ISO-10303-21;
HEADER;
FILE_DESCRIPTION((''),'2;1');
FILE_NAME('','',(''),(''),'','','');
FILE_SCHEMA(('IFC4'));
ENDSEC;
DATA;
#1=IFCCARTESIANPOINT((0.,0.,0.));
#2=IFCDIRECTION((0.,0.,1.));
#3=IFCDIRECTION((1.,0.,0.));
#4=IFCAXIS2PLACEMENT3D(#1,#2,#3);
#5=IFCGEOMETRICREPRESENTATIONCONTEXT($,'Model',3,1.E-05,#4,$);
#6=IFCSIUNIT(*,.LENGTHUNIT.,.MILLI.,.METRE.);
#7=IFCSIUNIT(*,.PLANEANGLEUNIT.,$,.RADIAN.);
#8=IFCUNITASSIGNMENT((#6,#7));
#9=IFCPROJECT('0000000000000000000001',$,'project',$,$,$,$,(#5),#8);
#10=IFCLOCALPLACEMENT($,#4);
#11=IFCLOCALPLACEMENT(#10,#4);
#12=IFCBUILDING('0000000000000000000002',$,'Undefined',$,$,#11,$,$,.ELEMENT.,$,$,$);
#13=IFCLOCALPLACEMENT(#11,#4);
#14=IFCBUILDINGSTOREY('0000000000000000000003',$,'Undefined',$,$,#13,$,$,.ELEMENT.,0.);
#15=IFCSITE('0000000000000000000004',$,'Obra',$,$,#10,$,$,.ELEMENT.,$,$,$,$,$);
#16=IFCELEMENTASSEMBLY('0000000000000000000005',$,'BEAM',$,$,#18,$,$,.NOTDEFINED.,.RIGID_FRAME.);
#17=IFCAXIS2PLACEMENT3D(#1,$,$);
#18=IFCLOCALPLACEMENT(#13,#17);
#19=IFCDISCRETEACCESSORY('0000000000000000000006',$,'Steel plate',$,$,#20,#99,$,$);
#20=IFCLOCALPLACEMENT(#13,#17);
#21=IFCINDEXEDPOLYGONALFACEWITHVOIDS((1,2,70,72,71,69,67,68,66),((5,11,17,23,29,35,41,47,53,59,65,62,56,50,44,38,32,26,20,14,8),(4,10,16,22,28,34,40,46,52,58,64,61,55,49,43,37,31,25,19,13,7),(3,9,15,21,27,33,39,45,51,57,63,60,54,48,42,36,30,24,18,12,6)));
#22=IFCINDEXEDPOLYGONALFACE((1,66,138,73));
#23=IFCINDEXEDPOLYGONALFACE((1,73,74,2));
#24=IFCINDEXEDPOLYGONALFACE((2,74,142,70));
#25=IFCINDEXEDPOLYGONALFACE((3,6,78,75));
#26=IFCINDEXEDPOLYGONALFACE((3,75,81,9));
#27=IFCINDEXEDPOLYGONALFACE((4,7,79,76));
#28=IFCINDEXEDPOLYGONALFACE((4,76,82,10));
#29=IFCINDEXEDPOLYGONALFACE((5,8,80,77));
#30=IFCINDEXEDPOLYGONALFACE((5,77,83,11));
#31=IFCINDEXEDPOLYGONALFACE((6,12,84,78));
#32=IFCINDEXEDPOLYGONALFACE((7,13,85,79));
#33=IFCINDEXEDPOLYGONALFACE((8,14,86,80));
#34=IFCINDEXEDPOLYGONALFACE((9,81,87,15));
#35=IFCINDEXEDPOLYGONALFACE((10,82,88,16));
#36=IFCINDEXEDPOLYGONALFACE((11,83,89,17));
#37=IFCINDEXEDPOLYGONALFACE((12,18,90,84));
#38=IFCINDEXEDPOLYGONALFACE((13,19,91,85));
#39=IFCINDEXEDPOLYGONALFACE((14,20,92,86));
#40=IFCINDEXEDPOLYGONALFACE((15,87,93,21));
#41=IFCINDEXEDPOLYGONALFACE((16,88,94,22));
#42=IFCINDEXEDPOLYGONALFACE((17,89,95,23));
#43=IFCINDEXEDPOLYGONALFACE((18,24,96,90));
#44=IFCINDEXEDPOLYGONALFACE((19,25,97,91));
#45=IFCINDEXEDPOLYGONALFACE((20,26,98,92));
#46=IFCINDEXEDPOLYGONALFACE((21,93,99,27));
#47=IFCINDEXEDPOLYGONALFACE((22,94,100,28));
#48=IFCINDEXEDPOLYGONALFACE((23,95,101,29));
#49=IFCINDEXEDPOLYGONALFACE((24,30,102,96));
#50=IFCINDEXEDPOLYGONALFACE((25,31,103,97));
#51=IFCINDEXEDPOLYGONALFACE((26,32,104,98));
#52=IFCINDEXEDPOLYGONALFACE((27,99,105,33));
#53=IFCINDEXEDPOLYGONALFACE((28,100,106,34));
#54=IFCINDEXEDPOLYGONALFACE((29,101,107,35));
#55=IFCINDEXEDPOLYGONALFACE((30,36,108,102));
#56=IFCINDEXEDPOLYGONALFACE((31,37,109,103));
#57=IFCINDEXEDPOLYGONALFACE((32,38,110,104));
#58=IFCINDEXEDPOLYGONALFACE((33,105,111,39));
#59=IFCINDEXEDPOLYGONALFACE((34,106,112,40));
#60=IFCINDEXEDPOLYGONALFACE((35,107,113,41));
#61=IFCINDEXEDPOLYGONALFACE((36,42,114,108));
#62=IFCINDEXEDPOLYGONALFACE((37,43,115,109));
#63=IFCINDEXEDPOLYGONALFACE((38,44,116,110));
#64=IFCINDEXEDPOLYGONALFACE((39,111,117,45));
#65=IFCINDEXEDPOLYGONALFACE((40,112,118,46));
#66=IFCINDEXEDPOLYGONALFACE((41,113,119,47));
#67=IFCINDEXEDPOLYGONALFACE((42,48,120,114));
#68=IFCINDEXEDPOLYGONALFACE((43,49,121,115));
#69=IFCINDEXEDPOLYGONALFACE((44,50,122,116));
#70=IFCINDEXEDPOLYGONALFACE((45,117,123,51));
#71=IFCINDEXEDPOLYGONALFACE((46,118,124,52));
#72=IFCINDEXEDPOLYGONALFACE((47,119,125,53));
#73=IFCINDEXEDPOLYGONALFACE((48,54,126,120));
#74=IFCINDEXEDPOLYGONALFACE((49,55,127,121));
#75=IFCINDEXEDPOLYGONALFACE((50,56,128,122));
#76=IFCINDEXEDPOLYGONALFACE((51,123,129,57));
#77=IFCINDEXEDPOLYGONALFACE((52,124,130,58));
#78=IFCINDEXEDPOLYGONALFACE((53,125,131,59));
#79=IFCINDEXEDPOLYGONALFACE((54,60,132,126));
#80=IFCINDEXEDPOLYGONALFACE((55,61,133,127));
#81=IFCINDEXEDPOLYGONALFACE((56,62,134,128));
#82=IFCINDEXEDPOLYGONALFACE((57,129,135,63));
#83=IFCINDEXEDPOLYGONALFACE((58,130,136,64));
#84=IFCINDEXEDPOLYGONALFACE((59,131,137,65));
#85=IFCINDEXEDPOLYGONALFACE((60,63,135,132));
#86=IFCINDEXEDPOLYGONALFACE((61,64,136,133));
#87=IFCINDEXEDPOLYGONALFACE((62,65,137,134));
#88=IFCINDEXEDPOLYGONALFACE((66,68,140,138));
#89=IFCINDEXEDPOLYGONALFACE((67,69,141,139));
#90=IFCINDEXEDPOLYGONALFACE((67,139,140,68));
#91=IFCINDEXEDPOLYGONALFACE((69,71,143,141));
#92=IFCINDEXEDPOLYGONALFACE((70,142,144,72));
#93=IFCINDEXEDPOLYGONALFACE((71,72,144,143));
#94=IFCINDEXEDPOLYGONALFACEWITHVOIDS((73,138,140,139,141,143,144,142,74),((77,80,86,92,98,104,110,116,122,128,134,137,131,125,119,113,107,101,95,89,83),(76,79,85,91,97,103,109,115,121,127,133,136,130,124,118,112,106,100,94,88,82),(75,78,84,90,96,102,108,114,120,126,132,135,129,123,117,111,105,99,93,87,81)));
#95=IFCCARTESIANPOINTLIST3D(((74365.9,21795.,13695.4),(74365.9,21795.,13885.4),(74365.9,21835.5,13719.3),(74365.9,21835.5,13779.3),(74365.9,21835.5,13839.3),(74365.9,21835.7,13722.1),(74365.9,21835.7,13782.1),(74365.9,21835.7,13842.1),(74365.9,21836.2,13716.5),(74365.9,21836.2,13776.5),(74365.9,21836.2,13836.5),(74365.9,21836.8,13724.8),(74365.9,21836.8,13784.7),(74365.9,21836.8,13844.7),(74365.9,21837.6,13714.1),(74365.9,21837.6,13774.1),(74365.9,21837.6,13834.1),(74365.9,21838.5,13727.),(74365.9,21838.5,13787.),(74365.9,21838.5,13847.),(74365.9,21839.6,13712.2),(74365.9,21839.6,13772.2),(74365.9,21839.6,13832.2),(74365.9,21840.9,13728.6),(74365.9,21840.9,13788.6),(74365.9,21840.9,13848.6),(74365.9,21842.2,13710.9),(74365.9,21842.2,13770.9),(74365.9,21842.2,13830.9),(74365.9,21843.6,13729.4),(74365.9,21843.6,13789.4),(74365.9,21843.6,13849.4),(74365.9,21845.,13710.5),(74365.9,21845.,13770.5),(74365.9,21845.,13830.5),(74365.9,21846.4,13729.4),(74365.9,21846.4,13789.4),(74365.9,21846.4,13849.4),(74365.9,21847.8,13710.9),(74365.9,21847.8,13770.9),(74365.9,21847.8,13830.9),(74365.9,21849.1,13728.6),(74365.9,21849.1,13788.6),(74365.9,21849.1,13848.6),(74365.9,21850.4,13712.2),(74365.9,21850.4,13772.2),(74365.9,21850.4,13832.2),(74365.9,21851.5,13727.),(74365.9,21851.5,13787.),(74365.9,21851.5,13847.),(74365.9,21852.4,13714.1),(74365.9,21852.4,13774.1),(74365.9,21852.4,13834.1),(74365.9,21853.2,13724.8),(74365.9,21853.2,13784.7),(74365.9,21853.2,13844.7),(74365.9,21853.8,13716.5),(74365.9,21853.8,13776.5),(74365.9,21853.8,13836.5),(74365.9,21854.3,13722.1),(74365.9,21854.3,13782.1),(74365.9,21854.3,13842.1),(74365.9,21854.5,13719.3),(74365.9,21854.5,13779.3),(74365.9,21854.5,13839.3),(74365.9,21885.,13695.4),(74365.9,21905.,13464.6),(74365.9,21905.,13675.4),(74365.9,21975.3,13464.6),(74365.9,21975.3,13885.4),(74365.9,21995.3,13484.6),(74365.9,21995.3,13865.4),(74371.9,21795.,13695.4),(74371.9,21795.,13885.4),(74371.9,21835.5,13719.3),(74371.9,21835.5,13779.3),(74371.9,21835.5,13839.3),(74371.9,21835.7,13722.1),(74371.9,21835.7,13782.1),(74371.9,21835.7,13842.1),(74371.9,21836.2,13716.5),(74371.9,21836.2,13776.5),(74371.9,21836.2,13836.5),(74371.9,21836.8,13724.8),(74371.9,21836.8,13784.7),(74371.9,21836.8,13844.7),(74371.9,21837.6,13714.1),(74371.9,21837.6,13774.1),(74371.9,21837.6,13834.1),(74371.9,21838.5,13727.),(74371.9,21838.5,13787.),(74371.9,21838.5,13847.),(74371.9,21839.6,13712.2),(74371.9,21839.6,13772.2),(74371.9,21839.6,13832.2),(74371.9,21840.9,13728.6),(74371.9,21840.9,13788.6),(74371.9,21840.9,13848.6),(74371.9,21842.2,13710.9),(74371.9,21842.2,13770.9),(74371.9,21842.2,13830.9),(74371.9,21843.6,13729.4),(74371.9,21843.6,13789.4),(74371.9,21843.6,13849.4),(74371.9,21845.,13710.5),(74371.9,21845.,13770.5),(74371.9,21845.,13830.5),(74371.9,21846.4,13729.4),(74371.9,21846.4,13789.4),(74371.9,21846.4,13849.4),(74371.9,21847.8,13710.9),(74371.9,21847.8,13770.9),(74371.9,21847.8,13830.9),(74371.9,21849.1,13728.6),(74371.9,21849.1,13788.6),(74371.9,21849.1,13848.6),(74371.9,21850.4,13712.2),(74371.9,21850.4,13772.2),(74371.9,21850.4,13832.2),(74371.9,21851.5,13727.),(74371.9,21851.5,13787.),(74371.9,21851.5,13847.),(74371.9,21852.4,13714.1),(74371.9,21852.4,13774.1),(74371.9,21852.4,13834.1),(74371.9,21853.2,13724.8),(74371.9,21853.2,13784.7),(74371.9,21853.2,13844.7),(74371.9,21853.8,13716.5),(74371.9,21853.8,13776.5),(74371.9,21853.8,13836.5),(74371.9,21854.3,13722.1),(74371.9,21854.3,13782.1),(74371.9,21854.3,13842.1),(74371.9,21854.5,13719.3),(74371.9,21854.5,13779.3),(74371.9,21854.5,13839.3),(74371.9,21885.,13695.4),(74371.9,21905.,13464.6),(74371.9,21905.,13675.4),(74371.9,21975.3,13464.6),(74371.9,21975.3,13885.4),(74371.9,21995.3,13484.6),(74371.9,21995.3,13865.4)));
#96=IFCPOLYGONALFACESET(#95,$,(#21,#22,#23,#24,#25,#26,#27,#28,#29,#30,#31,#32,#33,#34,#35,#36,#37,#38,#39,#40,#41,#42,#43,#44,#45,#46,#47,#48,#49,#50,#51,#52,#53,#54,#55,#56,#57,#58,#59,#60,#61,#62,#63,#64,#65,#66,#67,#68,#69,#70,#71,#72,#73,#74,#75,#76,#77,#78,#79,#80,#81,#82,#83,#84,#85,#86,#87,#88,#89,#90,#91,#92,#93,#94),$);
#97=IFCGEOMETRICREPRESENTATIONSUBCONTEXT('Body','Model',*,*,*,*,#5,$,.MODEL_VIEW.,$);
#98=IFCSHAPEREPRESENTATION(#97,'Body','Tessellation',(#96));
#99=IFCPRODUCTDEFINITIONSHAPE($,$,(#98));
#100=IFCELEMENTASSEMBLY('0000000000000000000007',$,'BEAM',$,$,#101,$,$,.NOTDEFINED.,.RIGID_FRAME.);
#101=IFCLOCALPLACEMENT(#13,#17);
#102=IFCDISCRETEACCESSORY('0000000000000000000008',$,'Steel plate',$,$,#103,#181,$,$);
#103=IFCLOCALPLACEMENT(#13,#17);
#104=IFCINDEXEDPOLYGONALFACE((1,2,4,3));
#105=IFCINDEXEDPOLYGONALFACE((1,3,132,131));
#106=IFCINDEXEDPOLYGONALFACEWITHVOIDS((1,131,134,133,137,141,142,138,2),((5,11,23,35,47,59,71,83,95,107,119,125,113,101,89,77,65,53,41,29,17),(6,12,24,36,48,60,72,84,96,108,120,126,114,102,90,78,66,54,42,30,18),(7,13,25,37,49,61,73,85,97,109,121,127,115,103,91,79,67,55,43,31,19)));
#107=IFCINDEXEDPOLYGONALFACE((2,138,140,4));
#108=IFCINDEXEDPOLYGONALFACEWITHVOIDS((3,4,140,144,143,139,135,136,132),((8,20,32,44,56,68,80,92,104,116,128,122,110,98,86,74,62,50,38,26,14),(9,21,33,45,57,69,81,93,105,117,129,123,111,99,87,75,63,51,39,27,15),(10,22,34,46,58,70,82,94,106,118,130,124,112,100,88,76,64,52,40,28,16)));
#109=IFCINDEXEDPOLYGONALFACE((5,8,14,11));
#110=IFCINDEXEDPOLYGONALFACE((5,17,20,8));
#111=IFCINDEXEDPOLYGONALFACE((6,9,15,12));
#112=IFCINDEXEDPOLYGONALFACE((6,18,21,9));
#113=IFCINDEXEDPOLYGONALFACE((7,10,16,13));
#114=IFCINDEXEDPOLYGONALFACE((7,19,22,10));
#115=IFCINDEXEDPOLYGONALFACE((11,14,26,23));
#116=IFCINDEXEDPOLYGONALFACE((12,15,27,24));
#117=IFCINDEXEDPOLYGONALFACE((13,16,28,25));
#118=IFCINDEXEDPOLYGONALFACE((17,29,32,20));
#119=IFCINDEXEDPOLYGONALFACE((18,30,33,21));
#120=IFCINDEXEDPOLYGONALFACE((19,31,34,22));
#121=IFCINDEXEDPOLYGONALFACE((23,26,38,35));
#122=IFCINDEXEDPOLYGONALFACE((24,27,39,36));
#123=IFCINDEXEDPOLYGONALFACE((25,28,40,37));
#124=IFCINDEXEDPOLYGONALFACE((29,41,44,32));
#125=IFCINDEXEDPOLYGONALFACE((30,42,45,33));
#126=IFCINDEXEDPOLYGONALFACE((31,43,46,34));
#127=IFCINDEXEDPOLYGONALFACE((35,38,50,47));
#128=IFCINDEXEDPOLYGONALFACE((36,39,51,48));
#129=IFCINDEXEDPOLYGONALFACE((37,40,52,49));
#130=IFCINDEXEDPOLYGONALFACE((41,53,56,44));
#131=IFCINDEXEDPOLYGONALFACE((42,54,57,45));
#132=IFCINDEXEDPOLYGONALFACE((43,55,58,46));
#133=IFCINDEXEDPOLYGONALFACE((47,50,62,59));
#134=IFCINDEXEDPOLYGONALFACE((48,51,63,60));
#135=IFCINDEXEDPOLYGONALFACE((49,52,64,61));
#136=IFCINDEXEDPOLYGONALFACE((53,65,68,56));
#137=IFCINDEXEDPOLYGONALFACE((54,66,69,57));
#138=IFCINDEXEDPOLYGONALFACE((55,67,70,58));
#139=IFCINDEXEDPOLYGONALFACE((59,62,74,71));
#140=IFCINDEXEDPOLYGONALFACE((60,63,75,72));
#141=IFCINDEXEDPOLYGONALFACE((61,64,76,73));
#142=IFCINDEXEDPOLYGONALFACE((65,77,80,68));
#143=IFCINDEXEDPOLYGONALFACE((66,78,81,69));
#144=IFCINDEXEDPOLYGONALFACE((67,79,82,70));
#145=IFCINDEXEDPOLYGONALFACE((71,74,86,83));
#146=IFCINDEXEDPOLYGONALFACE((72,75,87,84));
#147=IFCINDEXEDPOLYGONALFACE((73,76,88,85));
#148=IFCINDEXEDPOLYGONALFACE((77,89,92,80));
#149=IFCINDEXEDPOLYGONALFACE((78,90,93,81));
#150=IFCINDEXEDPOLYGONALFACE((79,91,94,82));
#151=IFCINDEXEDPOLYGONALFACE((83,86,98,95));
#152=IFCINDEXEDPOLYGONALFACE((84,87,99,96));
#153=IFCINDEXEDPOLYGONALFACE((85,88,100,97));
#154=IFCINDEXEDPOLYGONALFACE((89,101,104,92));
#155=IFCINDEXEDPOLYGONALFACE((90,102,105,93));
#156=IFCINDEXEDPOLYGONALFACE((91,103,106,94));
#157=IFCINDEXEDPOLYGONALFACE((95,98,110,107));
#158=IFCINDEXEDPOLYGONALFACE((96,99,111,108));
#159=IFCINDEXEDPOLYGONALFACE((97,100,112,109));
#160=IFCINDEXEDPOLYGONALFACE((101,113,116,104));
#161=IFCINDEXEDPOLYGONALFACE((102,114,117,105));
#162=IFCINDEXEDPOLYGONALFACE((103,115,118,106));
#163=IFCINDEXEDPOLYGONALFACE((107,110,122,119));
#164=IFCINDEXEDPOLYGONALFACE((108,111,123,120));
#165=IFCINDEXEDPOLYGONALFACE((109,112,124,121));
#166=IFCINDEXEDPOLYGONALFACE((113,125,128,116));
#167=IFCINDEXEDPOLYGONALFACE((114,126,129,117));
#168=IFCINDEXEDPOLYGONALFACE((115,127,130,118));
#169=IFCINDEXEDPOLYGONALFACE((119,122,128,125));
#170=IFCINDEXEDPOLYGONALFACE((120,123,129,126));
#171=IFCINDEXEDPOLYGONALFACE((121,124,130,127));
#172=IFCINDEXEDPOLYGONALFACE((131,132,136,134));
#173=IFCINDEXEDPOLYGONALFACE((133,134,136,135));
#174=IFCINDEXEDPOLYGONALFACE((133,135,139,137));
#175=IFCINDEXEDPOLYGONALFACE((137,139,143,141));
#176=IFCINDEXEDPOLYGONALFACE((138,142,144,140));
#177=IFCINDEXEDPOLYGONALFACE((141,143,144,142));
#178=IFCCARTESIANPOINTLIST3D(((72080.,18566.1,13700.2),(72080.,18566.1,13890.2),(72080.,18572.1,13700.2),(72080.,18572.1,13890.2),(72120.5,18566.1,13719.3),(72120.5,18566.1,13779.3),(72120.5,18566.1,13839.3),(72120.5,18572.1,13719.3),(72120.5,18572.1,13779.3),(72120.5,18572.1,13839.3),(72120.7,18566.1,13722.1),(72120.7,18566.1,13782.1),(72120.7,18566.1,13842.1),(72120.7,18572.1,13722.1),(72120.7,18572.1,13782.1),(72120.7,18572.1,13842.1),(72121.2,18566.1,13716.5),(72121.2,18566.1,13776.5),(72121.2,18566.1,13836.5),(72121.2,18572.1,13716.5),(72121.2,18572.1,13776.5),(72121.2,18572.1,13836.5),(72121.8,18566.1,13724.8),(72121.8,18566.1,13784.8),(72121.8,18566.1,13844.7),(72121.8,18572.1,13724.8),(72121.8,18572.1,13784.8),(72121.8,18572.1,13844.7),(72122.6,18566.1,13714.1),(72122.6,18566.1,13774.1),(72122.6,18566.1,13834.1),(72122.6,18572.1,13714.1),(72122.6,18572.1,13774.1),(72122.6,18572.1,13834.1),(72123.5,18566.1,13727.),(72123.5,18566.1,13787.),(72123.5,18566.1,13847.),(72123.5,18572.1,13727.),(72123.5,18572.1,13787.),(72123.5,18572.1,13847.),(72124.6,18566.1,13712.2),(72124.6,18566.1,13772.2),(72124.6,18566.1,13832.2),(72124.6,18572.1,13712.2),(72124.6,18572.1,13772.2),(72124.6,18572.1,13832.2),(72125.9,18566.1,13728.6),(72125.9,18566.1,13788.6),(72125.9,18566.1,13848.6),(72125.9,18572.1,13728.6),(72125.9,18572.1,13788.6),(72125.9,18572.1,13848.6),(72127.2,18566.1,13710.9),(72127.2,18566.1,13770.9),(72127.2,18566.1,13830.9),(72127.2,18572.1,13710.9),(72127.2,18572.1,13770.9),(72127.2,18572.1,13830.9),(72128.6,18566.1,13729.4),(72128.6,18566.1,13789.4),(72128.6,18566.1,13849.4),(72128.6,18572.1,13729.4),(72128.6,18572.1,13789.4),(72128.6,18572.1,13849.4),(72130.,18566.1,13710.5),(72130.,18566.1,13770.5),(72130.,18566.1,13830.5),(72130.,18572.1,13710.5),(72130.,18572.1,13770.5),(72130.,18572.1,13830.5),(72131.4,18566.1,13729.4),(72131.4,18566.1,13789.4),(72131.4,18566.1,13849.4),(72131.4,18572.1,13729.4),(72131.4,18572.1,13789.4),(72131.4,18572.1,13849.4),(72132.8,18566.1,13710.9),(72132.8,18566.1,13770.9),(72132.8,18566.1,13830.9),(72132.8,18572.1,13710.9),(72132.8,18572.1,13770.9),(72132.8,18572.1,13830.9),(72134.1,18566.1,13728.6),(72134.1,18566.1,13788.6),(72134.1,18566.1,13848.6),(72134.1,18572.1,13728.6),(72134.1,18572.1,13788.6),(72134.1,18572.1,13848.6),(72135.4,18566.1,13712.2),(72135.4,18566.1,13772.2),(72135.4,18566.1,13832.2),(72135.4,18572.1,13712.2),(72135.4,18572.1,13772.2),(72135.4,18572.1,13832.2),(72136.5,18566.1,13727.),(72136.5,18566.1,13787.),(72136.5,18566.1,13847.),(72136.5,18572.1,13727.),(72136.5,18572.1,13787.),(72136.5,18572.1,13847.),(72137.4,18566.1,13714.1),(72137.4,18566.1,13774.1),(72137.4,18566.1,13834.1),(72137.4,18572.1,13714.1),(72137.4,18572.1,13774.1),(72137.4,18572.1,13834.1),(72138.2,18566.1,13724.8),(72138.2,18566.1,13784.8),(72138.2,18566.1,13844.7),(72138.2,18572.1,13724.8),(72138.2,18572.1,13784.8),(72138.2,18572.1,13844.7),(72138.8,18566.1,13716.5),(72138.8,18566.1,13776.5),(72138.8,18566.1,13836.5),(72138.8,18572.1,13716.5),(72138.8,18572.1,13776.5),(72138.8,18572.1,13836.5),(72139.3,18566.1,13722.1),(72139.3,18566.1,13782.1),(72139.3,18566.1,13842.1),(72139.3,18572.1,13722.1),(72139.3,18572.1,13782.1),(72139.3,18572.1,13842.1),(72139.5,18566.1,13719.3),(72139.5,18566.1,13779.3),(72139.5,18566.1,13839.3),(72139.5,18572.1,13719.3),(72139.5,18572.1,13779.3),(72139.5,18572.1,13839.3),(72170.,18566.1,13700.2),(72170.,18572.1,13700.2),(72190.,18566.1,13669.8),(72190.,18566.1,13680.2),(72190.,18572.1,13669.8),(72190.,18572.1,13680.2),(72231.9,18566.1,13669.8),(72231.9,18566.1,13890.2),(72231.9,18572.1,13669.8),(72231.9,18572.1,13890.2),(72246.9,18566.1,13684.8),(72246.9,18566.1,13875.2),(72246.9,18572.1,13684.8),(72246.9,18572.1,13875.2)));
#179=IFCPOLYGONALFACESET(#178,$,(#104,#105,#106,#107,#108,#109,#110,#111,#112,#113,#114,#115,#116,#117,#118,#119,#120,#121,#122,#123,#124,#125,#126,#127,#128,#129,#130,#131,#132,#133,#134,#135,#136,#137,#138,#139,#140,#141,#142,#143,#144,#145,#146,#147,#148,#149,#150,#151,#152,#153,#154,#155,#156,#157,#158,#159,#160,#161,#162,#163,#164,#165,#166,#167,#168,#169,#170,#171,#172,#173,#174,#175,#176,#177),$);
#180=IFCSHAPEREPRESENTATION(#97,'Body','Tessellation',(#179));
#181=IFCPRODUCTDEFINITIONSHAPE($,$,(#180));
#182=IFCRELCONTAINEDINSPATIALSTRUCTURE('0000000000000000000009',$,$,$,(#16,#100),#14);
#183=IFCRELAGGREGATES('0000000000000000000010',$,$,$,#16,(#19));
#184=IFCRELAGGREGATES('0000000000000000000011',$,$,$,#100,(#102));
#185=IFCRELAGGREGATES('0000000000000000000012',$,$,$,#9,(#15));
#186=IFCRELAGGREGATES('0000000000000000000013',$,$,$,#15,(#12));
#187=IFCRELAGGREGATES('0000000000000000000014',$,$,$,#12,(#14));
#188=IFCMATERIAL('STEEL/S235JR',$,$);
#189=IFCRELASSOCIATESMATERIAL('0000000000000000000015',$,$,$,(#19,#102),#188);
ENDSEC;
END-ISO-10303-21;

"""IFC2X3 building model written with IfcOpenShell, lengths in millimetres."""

from ifc_helpers import new_model, si_unit, frame, origin_with_axes, origin_2d_with_axis, place, context, subcontext, project, spatial, polyline, circle, outline, extrude, source, transform, mapped, material, element, aggregate, save


model = new_model("IFC2X3")

# Units and contexts
model_context = context("Model", 3, precision=1e-05, world=origin_with_axes())
body_context = subcontext(model_context, "Body", "Model", "MODEL_VIEW")
ifc_project = project(units=[si_unit("LENGTHUNIT", "METRE", prefix="MILLI"), si_unit("PLANEANGLEUNIT", "RADIAN")], contexts=[model_context])

# Site, building, storey
site_placement = place(None, origin_with_axes())
site = spatial("IfcSite", under=ifc_project, at=site_placement, Name="Obra", CompositionType="ELEMENT")
building_placement = place(site_placement, origin_with_axes())
building = spatial("IfcBuilding", under=site, at=building_placement, Name="Undefined", CompositionType="ELEMENT")
storey_placement = place(building_placement, origin_with_axes())
storey = spatial("IfcBuildingStorey", under=building, at=storey_placement, Name="Undefined", CompositionType="ELEMENT", Elevation=0.0)

# Shared definitions
ifc_material_1 = material(Name="STEEL/S235JR")

# Element assembly
assembly_1_placement = place(storey_placement, origin_with_axes())
assembly_1 = element("IfcElementAssembly", 1, at=assembly_1_placement, inside=storey, Name="BEAM", AssemblyPlace="NOTDEFINED", PredefinedType="RIGID_FRAME")

# Discrete accessory, opening
discrete_accessory_1_placement = place(assembly_1_placement, frame((74368.9, 21995.3, 13484.6), z_axis=(-1.0, 0.0, 0.0), x_axis=(0.0, -0.707107, -0.707107)))
discrete_accessory_1 = element("IfcDiscreteAccessory", 2, at=discrete_accessory_1_placement, material=ifc_material_1, Name="Steel plate", context=body_context, shape_type="SweptSolid", body=[
    extrude(outline(polyline([(0.0, 0.0), (28.3, 0.0), (78.0, 49.7), (-71.1, 198.8), (-71.1, 227.1), (-7.4, 290.7), (-141.8, 425.0), (-269.3, 297.6), (-269.3, 269.3), (0.0, 0.0)])), frame((0.0, 0.0, -3.0), z_axis=(0.0, 0.0, 1.0), x_axis=(1.0, 0.0, 0.0)), (0.0, 0.0, 1.0), 6.0),
])
shared_shape_1 = source(origin_with_axes(), body_context, "Body", "SweptSolid", [
    extrude(circle(Radius=9.5, at=origin_2d_with_axis()), frame((0.0, -9.2, 0.0), z_axis=(0.0, 1.0, 0.0), x_axis=(1.0, 0.0, 0.0)), (0.0, 0.0, 1.0), 6.2),
])
opening_1_placement = place(assembly_1_placement, frame((74375.0, 21895.0, 13885.4), z_axis=(0.0, -1.0, 0.0), x_axis=(0.0, 0.0, -1.0)))
element("IfcOpeningElement", 3, at=opening_1_placement, cuts=discrete_accessory_1, ObjectType="Opening", context=body_context, shape_type="MappedRepresentation", body=[
    mapped(shared_shape_1, transform((165.4, 0.0, 50.0))),
    mapped(shared_shape_1, transform((105.4, 0.0, 50.0))),
    mapped(shared_shape_1, transform((45.4, 0.0, 50.0))),
])
aggregate(assembly_1, [discrete_accessory_1])

# Element assembly, discrete accessory, opening
assembly_2_placement = place(storey_placement, origin_with_axes())
assembly_2 = element("IfcElementAssembly", 4, at=assembly_2_placement, inside=storey, Name="BEAM", AssemblyPlace="NOTDEFINED", PredefinedType="RIGID_FRAME")
discrete_accessory_2_placement = place(assembly_2_placement, frame((72246.9, 18569.1, 13684.8), z_axis=(0.0, 1.0, 0.0), x_axis=(-0.707107, 0.0, -0.707107)))
discrete_accessory_2 = element("IfcDiscreteAccessory", 5, at=discrete_accessory_2_placement, material=ifc_material_1, Name="Steel plate", context=body_context, shape_type="SweptSolid", body=[
    extrude(outline(polyline([(0.0, 0.0), (21.2, 0.0), (50.8, 29.6), (43.5, 37.0), (43.5, 65.3), (107.1, 128.9), (-27.2, 263.3), (-134.6, 155.8), (-134.6, 134.6), (0.0, 0.0)])), frame((0.0, 0.0, -3.0), z_axis=(0.0, 0.0, 1.0), x_axis=(1.0, 0.0, 0.0)), (0.0, 0.0, 1.0), 6.0),
])
shared_shape_2 = source(origin_with_axes(), body_context, "Body", "SweptSolid", [
    extrude(circle(Radius=9.5, at=origin_2d_with_axis()), frame((0.0, -9.2, 0.0), z_axis=(0.0, 1.0, 0.0), x_axis=(1.0, 0.0, 0.0)), (0.0, 0.0, 1.0), 6.2),
])
opening_2_placement = place(assembly_2_placement, frame((72180.0, 18563.0, 13890.2), z_axis=(-1.0, 0.0, 0.0), x_axis=(0.0, 0.0, -1.0)))
element("IfcOpeningElement", 6, at=opening_2_placement, cuts=discrete_accessory_2, ObjectType="Opening", context=body_context, shape_type="MappedRepresentation", body=[
    mapped(shared_shape_2, transform((170.2, 0.0, 50.0))),
    mapped(shared_shape_2, transform((110.2, 0.0, 50.0))),
    mapped(shared_shape_2, transform((50.2, 0.0, 50.0))),
])
aggregate(assembly_2, [discrete_accessory_2])

save(model, "model.ifc")
